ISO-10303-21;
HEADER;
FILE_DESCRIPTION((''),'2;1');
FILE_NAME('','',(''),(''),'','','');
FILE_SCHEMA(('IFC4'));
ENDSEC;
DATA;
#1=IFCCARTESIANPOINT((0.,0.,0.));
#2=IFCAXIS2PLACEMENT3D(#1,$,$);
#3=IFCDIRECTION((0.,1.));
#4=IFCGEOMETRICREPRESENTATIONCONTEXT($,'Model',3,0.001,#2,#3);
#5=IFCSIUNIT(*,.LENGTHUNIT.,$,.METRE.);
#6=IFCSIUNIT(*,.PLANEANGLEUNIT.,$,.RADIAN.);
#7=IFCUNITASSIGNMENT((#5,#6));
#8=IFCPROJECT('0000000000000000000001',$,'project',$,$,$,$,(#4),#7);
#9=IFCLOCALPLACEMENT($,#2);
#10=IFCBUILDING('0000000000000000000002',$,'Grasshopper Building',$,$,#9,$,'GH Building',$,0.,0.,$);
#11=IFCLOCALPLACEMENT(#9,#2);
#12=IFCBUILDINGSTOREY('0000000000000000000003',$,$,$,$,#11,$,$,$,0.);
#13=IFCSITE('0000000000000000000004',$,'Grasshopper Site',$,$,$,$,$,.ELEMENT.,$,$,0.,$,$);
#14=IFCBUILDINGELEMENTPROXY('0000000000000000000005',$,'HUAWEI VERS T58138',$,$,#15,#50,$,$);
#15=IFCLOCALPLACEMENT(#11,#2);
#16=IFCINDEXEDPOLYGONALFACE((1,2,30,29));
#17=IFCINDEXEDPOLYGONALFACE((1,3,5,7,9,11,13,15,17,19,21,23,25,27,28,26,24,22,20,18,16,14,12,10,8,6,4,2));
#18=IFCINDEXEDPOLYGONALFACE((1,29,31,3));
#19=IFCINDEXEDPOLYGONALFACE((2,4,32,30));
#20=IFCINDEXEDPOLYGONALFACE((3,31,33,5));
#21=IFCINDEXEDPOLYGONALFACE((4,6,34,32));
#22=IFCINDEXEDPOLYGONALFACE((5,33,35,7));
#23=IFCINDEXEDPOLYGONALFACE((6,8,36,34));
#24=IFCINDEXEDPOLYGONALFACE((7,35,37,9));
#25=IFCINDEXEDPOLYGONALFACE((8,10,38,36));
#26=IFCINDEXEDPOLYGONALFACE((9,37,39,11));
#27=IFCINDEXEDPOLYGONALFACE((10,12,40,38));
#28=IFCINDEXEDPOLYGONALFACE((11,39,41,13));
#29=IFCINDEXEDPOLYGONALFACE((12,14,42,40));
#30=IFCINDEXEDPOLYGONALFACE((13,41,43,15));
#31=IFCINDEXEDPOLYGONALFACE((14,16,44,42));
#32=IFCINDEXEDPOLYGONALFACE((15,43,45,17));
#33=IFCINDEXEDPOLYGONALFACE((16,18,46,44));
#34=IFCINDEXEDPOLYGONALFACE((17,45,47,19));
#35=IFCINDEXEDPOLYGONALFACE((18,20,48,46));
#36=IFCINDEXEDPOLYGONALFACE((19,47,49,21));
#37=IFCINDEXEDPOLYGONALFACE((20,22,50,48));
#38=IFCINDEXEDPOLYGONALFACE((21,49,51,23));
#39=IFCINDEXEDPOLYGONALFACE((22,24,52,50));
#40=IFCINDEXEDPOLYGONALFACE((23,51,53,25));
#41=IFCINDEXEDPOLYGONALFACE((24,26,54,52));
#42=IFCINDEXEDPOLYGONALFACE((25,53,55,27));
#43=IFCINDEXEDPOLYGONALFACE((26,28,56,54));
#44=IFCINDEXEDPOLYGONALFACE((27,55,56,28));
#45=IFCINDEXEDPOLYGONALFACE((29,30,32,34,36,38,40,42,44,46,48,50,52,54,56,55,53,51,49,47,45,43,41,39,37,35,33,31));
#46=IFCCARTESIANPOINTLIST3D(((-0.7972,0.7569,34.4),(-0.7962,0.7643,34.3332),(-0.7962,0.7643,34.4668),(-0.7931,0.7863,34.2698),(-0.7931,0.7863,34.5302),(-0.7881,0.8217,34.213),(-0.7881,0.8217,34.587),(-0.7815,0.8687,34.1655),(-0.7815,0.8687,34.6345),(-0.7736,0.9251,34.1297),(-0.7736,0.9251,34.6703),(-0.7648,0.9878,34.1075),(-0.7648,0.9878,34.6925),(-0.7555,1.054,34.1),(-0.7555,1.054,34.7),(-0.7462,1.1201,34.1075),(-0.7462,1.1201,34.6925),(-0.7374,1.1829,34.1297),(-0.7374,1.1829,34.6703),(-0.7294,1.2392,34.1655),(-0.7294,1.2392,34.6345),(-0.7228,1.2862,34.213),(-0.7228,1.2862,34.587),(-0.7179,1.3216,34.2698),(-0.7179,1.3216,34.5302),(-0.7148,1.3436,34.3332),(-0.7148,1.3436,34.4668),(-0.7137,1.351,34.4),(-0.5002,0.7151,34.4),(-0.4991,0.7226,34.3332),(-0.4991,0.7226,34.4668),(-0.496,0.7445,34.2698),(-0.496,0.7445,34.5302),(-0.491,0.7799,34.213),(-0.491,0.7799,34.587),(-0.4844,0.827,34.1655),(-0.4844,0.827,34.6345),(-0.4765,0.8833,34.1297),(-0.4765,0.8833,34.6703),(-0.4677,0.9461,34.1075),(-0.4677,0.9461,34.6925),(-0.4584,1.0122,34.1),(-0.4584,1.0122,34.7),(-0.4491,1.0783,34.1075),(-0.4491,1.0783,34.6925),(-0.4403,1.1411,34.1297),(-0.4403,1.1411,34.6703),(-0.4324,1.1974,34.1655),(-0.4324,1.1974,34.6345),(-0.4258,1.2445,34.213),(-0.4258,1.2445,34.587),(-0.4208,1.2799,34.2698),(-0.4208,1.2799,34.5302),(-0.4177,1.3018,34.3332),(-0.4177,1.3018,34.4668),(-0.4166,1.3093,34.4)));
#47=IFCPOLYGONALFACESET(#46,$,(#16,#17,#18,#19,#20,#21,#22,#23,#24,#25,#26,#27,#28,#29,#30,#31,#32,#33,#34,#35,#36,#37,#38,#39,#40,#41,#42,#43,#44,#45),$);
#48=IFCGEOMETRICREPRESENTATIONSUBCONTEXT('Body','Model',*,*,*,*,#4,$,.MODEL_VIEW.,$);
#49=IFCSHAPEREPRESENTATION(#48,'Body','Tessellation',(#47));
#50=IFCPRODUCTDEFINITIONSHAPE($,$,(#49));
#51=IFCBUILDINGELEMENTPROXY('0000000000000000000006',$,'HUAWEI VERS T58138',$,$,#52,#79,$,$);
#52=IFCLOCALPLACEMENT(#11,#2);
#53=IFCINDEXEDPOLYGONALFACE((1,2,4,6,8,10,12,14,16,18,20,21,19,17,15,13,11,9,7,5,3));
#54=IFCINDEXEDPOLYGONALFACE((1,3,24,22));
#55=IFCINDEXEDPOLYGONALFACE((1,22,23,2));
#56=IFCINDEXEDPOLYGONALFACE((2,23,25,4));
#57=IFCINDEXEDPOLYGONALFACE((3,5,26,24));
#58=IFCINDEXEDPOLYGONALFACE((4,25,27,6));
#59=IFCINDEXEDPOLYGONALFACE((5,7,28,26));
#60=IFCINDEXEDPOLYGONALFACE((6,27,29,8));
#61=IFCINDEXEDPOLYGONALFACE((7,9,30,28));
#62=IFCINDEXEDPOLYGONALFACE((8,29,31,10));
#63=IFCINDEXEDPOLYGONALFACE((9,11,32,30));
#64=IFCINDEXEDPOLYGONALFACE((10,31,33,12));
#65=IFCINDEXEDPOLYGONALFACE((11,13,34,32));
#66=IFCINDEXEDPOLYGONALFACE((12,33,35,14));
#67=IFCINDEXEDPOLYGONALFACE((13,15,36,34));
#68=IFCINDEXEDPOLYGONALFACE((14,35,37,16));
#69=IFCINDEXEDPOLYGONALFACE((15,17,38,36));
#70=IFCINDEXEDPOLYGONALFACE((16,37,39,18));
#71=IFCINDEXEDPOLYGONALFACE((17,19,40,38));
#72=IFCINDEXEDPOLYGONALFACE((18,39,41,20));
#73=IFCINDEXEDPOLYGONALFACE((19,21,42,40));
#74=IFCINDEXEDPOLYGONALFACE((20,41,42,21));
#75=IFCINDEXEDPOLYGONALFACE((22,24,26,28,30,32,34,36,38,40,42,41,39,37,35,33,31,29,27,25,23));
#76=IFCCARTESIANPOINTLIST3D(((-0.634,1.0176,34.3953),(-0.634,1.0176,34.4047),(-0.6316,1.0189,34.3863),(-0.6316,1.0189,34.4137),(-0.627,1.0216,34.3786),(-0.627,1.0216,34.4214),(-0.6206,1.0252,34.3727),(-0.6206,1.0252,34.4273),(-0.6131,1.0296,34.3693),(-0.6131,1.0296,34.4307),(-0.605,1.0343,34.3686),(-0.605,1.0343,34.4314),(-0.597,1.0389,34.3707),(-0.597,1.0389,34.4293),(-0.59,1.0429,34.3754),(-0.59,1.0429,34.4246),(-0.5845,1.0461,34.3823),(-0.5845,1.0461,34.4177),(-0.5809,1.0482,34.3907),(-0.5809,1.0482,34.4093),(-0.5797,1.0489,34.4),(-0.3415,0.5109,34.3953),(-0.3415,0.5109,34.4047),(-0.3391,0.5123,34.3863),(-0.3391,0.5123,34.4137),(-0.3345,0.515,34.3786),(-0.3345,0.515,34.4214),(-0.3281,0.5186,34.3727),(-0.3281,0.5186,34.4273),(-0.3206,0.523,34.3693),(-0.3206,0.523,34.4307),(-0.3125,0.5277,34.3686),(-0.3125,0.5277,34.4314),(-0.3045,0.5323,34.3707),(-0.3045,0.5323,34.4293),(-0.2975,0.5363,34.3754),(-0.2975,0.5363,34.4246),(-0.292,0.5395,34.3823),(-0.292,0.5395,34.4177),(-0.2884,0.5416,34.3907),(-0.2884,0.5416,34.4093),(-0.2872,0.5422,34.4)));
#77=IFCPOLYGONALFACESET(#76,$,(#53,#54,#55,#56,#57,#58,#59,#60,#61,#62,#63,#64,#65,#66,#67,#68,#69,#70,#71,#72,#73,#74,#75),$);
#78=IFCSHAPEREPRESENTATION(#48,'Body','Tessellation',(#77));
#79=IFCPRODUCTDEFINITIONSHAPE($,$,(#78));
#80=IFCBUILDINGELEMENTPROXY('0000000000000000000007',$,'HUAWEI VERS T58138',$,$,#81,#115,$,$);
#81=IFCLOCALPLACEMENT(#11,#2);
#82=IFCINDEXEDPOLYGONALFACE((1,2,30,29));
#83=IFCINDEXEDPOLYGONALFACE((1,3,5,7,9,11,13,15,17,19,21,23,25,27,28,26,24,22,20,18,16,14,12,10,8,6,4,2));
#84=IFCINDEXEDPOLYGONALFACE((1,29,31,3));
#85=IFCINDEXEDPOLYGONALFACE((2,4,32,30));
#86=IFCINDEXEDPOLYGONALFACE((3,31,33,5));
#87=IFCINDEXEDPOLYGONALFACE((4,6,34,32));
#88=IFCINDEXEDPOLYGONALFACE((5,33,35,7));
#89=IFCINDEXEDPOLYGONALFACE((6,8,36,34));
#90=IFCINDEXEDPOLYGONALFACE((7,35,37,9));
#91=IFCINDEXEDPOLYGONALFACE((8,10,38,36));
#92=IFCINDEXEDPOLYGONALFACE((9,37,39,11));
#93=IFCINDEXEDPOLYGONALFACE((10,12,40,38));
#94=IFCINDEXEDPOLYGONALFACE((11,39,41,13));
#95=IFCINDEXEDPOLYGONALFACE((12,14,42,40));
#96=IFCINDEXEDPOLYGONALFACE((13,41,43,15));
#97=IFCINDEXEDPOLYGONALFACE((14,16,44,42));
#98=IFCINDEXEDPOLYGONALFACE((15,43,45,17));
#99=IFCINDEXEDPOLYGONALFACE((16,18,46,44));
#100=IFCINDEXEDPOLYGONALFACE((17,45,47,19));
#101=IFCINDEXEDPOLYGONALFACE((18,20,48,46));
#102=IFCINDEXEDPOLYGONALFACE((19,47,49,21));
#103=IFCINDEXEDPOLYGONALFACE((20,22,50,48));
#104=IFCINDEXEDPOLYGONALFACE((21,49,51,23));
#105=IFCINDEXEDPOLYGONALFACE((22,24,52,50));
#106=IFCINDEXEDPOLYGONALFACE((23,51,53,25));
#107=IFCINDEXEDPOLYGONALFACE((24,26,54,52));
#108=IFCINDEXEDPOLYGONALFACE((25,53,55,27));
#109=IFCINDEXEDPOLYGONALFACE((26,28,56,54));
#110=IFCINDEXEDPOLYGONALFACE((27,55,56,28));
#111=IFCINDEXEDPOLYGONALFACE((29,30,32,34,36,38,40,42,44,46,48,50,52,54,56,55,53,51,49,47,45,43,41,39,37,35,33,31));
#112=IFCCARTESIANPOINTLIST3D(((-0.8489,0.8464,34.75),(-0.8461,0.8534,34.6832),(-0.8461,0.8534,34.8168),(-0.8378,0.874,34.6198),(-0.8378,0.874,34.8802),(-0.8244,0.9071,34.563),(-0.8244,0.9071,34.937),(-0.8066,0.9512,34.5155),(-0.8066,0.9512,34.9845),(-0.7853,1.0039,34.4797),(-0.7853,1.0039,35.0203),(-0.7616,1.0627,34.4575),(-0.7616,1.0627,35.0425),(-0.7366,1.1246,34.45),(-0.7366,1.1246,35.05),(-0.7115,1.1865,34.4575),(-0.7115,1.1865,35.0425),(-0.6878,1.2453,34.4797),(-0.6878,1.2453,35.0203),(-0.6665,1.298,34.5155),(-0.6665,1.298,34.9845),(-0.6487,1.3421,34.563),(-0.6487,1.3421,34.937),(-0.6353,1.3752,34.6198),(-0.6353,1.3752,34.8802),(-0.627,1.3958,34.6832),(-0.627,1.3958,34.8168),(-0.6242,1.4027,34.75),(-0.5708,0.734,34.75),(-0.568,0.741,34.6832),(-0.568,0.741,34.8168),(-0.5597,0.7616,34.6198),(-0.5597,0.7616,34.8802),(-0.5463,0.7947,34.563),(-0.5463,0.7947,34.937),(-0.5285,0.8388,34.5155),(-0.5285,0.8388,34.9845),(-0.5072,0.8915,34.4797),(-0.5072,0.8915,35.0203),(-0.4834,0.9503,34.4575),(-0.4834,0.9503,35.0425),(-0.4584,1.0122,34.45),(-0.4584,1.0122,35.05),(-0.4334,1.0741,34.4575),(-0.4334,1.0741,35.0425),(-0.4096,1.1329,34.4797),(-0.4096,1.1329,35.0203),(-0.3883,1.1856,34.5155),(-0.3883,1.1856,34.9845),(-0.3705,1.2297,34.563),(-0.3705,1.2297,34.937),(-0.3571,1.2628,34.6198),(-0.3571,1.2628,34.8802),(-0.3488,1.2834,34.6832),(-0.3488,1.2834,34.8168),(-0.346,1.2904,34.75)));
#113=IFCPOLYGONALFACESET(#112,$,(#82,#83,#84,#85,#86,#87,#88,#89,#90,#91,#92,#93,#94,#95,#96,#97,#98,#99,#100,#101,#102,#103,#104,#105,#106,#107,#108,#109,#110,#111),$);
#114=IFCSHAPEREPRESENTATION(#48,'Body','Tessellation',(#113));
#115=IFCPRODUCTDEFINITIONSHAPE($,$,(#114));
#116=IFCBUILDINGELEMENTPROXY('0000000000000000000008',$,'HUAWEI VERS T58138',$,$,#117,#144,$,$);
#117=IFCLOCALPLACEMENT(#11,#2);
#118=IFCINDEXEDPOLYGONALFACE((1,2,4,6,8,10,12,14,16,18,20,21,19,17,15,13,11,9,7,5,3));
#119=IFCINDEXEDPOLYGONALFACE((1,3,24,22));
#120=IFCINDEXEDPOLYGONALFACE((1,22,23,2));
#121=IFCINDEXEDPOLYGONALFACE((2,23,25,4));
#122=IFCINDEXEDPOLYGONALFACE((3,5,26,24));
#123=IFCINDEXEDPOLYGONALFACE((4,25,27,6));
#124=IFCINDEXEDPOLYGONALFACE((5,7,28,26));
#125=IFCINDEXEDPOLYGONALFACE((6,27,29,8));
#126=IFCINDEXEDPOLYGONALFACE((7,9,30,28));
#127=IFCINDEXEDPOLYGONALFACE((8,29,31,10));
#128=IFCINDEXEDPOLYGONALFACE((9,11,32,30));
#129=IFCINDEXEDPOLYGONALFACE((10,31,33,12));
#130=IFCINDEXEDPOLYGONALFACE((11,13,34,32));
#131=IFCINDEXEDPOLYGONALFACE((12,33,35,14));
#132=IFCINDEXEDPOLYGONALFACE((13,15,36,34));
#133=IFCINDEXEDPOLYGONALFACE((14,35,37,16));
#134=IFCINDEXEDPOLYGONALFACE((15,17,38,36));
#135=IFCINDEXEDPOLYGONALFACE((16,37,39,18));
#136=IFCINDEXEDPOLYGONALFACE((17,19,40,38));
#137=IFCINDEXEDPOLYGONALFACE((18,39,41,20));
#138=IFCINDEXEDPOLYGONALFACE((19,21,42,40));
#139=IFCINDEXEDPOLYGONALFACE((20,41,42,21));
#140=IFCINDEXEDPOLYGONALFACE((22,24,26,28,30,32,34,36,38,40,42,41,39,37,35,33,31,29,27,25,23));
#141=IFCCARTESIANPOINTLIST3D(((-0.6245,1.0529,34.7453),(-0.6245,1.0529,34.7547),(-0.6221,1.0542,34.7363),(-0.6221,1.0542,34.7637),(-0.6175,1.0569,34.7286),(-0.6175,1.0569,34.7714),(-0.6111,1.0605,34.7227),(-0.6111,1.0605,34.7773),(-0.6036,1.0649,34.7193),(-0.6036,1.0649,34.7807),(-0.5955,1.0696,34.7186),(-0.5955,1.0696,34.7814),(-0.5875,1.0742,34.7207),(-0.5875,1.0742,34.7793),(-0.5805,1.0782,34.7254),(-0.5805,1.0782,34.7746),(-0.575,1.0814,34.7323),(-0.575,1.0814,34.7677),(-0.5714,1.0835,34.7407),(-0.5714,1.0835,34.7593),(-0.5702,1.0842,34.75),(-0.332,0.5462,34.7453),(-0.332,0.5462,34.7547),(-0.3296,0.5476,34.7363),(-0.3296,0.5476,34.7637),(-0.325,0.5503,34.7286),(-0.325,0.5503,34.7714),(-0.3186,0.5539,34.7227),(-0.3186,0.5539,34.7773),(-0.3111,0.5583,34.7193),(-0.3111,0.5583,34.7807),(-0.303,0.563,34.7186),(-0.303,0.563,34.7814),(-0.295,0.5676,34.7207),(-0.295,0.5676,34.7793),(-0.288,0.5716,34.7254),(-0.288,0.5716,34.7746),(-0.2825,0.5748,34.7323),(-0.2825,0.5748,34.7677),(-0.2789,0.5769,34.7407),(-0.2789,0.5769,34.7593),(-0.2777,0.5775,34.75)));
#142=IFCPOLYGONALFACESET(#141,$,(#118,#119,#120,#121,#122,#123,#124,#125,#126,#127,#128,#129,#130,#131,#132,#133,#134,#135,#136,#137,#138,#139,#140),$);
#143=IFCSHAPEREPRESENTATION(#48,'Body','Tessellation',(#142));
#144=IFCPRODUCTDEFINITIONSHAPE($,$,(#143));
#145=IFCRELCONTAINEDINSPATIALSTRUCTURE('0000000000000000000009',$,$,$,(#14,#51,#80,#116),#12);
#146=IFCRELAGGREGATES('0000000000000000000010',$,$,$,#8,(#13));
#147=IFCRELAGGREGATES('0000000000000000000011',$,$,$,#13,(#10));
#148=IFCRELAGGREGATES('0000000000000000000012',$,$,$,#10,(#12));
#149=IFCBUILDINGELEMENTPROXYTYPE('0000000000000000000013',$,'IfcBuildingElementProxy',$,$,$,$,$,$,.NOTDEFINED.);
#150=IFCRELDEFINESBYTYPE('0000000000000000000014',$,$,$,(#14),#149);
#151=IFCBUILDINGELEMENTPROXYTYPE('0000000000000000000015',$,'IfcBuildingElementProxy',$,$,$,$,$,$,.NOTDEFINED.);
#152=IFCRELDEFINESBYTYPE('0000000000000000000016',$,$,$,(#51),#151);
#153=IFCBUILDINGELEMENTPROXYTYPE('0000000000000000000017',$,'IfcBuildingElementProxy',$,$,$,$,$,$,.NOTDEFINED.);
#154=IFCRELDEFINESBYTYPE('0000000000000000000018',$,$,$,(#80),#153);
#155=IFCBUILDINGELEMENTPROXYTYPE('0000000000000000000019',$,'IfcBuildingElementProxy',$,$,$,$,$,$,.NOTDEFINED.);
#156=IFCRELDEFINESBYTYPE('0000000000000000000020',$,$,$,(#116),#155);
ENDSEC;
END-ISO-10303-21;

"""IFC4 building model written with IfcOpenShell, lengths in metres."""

from ifc_helpers import new_model, si_unit, direction, frame, origin, place, context, subcontext, project, spatial, circle, extrude, source, transform, mapped, type_object, type_shapes, element, save


model = new_model("IFC4")

# Units and contexts
model_context = context("Model", 3, precision=0.001, world=origin(), true_north=direction((0.0, 1.0)))
body_context = subcontext(model_context, "Body", "Model", "MODEL_VIEW")
ifc_project = project(units=[si_unit("LENGTHUNIT", "METRE"), si_unit("PLANEANGLEUNIT", "RADIAN")], contexts=[model_context])

# Site, building, storey
site = spatial("IfcSite", under=ifc_project, Name="Grasshopper Site", CompositionType="ELEMENT", RefElevation=0.0)
building_placement = place(None, origin())
building = spatial("IfcBuilding", under=site, at=building_placement, Name="Grasshopper Building", LongName="GH Building", ElevationOfRefHeight=0.0, ElevationOfTerrain=0.0)
storey_placement = place(building_placement, origin())
storey = spatial("IfcBuildingStorey", under=building, at=storey_placement, Elevation=0.0)

# Building element proxies
building_element_proxy_type_1 = type_object("IfcBuildingElementProxyType", Name="IfcBuildingElementProxy", PredefinedType="NOTDEFINED")
shared_shape_1 = source(origin(), body_context, "Body", "SweptSolid", [
    extrude(circle(Radius=0.3), frame((-0.4584, 1.0122, 34.4), z_axis=(-0.990268, 0.139173, 0.0), x_axis=(0.139173, 0.990268, 0.0)), (0.0, 0.0, 1.0), 0.3),
])
type_shapes(building_element_proxy_type_1, [shared_shape_1])
for number, where, name in (
    (1, (0.0, 0.0, 0.0), "HUAWEI VERS T58138"),
):
    element("IfcBuildingElementProxy", number, at=place(storey_placement, frame(where)), inside=storey, type_object=building_element_proxy_type_1, Name=name, context=body_context, shape_type="MappedRepresentation", body=[
        mapped(shared_shape_1, transform((0.0, 0.0, 0.0), scale=1.0)),
    ])
building_element_proxy_type_2 = type_object("IfcBuildingElementProxyType", Name="IfcBuildingElementProxy", PredefinedType="NOTDEFINED")
shared_shape_2 = source(origin(), body_context, "Body", "SweptSolid", [
    extrude(circle(Radius=0.0315), frame((-0.3145, 0.5265, 34.4), z_axis=(-0.5, 0.866025, 0.0), x_axis=(0.866025, 0.5, 0.0)), (0.0, 0.0, 1.0), 0.585),
])
type_shapes(building_element_proxy_type_2, [shared_shape_2])
for number, where, name in (
    (2, (0.0, 0.0, 0.0), "HUAWEI VERS T58138"),
):
    element("IfcBuildingElementProxy", number, at=place(storey_placement, frame(where)), inside=storey, type_object=building_element_proxy_type_2, Name=name, context=body_context, shape_type="MappedRepresentation", body=[
        mapped(shared_shape_2, transform((0.0, 0.0, 0.0), scale=1.0)),
    ])
building_element_proxy_type_3 = type_object("IfcBuildingElementProxyType", Name="IfcBuildingElementProxy", PredefinedType="NOTDEFINED")
shared_shape_3 = source(origin(), body_context, "Body", "SweptSolid", [
    extrude(circle(Radius=0.3), frame((-0.4584, 1.0122, 34.75), z_axis=(-0.927184, 0.374607, 0.0), x_axis=(0.374607, 0.927184, 0.0)), (0.0, 0.0, 1.0), 0.3),
])
type_shapes(building_element_proxy_type_3, [shared_shape_3])
for number, where, name in (
    (3, (0.0, 0.0, 0.0), "HUAWEI VERS T58138"),
):
    element("IfcBuildingElementProxy", number, at=place(storey_placement, frame(where)), inside=storey, type_object=building_element_proxy_type_3, Name=name, context=body_context, shape_type="MappedRepresentation", body=[
        mapped(shared_shape_3, transform((0.0, 0.0, 0.0), scale=1.0)),
    ])
building_element_proxy_type_4 = type_object("IfcBuildingElementProxyType", Name="IfcBuildingElementProxy", PredefinedType="NOTDEFINED")
shared_shape_4 = source(origin(), body_context, "Body", "SweptSolid", [
    extrude(circle(Radius=0.0315), frame((-0.305, 0.5618, 34.75), z_axis=(-0.5, 0.866025, 0.0), x_axis=(0.866025, 0.5, 0.0)), (0.0, 0.0, 1.0), 0.585),
])
type_shapes(building_element_proxy_type_4, [shared_shape_4])
for number, where, name in (
    (4, (0.0, 0.0, 0.0), "HUAWEI VERS T58138"),
):
    element("IfcBuildingElementProxy", number, at=place(storey_placement, frame(where)), inside=storey, type_object=building_element_proxy_type_4, Name=name, context=body_context, shape_type="MappedRepresentation", body=[
        mapped(shared_shape_4, transform((0.0, 0.0, 0.0), scale=1.0)),
    ])

save(model, "model.ifc")
